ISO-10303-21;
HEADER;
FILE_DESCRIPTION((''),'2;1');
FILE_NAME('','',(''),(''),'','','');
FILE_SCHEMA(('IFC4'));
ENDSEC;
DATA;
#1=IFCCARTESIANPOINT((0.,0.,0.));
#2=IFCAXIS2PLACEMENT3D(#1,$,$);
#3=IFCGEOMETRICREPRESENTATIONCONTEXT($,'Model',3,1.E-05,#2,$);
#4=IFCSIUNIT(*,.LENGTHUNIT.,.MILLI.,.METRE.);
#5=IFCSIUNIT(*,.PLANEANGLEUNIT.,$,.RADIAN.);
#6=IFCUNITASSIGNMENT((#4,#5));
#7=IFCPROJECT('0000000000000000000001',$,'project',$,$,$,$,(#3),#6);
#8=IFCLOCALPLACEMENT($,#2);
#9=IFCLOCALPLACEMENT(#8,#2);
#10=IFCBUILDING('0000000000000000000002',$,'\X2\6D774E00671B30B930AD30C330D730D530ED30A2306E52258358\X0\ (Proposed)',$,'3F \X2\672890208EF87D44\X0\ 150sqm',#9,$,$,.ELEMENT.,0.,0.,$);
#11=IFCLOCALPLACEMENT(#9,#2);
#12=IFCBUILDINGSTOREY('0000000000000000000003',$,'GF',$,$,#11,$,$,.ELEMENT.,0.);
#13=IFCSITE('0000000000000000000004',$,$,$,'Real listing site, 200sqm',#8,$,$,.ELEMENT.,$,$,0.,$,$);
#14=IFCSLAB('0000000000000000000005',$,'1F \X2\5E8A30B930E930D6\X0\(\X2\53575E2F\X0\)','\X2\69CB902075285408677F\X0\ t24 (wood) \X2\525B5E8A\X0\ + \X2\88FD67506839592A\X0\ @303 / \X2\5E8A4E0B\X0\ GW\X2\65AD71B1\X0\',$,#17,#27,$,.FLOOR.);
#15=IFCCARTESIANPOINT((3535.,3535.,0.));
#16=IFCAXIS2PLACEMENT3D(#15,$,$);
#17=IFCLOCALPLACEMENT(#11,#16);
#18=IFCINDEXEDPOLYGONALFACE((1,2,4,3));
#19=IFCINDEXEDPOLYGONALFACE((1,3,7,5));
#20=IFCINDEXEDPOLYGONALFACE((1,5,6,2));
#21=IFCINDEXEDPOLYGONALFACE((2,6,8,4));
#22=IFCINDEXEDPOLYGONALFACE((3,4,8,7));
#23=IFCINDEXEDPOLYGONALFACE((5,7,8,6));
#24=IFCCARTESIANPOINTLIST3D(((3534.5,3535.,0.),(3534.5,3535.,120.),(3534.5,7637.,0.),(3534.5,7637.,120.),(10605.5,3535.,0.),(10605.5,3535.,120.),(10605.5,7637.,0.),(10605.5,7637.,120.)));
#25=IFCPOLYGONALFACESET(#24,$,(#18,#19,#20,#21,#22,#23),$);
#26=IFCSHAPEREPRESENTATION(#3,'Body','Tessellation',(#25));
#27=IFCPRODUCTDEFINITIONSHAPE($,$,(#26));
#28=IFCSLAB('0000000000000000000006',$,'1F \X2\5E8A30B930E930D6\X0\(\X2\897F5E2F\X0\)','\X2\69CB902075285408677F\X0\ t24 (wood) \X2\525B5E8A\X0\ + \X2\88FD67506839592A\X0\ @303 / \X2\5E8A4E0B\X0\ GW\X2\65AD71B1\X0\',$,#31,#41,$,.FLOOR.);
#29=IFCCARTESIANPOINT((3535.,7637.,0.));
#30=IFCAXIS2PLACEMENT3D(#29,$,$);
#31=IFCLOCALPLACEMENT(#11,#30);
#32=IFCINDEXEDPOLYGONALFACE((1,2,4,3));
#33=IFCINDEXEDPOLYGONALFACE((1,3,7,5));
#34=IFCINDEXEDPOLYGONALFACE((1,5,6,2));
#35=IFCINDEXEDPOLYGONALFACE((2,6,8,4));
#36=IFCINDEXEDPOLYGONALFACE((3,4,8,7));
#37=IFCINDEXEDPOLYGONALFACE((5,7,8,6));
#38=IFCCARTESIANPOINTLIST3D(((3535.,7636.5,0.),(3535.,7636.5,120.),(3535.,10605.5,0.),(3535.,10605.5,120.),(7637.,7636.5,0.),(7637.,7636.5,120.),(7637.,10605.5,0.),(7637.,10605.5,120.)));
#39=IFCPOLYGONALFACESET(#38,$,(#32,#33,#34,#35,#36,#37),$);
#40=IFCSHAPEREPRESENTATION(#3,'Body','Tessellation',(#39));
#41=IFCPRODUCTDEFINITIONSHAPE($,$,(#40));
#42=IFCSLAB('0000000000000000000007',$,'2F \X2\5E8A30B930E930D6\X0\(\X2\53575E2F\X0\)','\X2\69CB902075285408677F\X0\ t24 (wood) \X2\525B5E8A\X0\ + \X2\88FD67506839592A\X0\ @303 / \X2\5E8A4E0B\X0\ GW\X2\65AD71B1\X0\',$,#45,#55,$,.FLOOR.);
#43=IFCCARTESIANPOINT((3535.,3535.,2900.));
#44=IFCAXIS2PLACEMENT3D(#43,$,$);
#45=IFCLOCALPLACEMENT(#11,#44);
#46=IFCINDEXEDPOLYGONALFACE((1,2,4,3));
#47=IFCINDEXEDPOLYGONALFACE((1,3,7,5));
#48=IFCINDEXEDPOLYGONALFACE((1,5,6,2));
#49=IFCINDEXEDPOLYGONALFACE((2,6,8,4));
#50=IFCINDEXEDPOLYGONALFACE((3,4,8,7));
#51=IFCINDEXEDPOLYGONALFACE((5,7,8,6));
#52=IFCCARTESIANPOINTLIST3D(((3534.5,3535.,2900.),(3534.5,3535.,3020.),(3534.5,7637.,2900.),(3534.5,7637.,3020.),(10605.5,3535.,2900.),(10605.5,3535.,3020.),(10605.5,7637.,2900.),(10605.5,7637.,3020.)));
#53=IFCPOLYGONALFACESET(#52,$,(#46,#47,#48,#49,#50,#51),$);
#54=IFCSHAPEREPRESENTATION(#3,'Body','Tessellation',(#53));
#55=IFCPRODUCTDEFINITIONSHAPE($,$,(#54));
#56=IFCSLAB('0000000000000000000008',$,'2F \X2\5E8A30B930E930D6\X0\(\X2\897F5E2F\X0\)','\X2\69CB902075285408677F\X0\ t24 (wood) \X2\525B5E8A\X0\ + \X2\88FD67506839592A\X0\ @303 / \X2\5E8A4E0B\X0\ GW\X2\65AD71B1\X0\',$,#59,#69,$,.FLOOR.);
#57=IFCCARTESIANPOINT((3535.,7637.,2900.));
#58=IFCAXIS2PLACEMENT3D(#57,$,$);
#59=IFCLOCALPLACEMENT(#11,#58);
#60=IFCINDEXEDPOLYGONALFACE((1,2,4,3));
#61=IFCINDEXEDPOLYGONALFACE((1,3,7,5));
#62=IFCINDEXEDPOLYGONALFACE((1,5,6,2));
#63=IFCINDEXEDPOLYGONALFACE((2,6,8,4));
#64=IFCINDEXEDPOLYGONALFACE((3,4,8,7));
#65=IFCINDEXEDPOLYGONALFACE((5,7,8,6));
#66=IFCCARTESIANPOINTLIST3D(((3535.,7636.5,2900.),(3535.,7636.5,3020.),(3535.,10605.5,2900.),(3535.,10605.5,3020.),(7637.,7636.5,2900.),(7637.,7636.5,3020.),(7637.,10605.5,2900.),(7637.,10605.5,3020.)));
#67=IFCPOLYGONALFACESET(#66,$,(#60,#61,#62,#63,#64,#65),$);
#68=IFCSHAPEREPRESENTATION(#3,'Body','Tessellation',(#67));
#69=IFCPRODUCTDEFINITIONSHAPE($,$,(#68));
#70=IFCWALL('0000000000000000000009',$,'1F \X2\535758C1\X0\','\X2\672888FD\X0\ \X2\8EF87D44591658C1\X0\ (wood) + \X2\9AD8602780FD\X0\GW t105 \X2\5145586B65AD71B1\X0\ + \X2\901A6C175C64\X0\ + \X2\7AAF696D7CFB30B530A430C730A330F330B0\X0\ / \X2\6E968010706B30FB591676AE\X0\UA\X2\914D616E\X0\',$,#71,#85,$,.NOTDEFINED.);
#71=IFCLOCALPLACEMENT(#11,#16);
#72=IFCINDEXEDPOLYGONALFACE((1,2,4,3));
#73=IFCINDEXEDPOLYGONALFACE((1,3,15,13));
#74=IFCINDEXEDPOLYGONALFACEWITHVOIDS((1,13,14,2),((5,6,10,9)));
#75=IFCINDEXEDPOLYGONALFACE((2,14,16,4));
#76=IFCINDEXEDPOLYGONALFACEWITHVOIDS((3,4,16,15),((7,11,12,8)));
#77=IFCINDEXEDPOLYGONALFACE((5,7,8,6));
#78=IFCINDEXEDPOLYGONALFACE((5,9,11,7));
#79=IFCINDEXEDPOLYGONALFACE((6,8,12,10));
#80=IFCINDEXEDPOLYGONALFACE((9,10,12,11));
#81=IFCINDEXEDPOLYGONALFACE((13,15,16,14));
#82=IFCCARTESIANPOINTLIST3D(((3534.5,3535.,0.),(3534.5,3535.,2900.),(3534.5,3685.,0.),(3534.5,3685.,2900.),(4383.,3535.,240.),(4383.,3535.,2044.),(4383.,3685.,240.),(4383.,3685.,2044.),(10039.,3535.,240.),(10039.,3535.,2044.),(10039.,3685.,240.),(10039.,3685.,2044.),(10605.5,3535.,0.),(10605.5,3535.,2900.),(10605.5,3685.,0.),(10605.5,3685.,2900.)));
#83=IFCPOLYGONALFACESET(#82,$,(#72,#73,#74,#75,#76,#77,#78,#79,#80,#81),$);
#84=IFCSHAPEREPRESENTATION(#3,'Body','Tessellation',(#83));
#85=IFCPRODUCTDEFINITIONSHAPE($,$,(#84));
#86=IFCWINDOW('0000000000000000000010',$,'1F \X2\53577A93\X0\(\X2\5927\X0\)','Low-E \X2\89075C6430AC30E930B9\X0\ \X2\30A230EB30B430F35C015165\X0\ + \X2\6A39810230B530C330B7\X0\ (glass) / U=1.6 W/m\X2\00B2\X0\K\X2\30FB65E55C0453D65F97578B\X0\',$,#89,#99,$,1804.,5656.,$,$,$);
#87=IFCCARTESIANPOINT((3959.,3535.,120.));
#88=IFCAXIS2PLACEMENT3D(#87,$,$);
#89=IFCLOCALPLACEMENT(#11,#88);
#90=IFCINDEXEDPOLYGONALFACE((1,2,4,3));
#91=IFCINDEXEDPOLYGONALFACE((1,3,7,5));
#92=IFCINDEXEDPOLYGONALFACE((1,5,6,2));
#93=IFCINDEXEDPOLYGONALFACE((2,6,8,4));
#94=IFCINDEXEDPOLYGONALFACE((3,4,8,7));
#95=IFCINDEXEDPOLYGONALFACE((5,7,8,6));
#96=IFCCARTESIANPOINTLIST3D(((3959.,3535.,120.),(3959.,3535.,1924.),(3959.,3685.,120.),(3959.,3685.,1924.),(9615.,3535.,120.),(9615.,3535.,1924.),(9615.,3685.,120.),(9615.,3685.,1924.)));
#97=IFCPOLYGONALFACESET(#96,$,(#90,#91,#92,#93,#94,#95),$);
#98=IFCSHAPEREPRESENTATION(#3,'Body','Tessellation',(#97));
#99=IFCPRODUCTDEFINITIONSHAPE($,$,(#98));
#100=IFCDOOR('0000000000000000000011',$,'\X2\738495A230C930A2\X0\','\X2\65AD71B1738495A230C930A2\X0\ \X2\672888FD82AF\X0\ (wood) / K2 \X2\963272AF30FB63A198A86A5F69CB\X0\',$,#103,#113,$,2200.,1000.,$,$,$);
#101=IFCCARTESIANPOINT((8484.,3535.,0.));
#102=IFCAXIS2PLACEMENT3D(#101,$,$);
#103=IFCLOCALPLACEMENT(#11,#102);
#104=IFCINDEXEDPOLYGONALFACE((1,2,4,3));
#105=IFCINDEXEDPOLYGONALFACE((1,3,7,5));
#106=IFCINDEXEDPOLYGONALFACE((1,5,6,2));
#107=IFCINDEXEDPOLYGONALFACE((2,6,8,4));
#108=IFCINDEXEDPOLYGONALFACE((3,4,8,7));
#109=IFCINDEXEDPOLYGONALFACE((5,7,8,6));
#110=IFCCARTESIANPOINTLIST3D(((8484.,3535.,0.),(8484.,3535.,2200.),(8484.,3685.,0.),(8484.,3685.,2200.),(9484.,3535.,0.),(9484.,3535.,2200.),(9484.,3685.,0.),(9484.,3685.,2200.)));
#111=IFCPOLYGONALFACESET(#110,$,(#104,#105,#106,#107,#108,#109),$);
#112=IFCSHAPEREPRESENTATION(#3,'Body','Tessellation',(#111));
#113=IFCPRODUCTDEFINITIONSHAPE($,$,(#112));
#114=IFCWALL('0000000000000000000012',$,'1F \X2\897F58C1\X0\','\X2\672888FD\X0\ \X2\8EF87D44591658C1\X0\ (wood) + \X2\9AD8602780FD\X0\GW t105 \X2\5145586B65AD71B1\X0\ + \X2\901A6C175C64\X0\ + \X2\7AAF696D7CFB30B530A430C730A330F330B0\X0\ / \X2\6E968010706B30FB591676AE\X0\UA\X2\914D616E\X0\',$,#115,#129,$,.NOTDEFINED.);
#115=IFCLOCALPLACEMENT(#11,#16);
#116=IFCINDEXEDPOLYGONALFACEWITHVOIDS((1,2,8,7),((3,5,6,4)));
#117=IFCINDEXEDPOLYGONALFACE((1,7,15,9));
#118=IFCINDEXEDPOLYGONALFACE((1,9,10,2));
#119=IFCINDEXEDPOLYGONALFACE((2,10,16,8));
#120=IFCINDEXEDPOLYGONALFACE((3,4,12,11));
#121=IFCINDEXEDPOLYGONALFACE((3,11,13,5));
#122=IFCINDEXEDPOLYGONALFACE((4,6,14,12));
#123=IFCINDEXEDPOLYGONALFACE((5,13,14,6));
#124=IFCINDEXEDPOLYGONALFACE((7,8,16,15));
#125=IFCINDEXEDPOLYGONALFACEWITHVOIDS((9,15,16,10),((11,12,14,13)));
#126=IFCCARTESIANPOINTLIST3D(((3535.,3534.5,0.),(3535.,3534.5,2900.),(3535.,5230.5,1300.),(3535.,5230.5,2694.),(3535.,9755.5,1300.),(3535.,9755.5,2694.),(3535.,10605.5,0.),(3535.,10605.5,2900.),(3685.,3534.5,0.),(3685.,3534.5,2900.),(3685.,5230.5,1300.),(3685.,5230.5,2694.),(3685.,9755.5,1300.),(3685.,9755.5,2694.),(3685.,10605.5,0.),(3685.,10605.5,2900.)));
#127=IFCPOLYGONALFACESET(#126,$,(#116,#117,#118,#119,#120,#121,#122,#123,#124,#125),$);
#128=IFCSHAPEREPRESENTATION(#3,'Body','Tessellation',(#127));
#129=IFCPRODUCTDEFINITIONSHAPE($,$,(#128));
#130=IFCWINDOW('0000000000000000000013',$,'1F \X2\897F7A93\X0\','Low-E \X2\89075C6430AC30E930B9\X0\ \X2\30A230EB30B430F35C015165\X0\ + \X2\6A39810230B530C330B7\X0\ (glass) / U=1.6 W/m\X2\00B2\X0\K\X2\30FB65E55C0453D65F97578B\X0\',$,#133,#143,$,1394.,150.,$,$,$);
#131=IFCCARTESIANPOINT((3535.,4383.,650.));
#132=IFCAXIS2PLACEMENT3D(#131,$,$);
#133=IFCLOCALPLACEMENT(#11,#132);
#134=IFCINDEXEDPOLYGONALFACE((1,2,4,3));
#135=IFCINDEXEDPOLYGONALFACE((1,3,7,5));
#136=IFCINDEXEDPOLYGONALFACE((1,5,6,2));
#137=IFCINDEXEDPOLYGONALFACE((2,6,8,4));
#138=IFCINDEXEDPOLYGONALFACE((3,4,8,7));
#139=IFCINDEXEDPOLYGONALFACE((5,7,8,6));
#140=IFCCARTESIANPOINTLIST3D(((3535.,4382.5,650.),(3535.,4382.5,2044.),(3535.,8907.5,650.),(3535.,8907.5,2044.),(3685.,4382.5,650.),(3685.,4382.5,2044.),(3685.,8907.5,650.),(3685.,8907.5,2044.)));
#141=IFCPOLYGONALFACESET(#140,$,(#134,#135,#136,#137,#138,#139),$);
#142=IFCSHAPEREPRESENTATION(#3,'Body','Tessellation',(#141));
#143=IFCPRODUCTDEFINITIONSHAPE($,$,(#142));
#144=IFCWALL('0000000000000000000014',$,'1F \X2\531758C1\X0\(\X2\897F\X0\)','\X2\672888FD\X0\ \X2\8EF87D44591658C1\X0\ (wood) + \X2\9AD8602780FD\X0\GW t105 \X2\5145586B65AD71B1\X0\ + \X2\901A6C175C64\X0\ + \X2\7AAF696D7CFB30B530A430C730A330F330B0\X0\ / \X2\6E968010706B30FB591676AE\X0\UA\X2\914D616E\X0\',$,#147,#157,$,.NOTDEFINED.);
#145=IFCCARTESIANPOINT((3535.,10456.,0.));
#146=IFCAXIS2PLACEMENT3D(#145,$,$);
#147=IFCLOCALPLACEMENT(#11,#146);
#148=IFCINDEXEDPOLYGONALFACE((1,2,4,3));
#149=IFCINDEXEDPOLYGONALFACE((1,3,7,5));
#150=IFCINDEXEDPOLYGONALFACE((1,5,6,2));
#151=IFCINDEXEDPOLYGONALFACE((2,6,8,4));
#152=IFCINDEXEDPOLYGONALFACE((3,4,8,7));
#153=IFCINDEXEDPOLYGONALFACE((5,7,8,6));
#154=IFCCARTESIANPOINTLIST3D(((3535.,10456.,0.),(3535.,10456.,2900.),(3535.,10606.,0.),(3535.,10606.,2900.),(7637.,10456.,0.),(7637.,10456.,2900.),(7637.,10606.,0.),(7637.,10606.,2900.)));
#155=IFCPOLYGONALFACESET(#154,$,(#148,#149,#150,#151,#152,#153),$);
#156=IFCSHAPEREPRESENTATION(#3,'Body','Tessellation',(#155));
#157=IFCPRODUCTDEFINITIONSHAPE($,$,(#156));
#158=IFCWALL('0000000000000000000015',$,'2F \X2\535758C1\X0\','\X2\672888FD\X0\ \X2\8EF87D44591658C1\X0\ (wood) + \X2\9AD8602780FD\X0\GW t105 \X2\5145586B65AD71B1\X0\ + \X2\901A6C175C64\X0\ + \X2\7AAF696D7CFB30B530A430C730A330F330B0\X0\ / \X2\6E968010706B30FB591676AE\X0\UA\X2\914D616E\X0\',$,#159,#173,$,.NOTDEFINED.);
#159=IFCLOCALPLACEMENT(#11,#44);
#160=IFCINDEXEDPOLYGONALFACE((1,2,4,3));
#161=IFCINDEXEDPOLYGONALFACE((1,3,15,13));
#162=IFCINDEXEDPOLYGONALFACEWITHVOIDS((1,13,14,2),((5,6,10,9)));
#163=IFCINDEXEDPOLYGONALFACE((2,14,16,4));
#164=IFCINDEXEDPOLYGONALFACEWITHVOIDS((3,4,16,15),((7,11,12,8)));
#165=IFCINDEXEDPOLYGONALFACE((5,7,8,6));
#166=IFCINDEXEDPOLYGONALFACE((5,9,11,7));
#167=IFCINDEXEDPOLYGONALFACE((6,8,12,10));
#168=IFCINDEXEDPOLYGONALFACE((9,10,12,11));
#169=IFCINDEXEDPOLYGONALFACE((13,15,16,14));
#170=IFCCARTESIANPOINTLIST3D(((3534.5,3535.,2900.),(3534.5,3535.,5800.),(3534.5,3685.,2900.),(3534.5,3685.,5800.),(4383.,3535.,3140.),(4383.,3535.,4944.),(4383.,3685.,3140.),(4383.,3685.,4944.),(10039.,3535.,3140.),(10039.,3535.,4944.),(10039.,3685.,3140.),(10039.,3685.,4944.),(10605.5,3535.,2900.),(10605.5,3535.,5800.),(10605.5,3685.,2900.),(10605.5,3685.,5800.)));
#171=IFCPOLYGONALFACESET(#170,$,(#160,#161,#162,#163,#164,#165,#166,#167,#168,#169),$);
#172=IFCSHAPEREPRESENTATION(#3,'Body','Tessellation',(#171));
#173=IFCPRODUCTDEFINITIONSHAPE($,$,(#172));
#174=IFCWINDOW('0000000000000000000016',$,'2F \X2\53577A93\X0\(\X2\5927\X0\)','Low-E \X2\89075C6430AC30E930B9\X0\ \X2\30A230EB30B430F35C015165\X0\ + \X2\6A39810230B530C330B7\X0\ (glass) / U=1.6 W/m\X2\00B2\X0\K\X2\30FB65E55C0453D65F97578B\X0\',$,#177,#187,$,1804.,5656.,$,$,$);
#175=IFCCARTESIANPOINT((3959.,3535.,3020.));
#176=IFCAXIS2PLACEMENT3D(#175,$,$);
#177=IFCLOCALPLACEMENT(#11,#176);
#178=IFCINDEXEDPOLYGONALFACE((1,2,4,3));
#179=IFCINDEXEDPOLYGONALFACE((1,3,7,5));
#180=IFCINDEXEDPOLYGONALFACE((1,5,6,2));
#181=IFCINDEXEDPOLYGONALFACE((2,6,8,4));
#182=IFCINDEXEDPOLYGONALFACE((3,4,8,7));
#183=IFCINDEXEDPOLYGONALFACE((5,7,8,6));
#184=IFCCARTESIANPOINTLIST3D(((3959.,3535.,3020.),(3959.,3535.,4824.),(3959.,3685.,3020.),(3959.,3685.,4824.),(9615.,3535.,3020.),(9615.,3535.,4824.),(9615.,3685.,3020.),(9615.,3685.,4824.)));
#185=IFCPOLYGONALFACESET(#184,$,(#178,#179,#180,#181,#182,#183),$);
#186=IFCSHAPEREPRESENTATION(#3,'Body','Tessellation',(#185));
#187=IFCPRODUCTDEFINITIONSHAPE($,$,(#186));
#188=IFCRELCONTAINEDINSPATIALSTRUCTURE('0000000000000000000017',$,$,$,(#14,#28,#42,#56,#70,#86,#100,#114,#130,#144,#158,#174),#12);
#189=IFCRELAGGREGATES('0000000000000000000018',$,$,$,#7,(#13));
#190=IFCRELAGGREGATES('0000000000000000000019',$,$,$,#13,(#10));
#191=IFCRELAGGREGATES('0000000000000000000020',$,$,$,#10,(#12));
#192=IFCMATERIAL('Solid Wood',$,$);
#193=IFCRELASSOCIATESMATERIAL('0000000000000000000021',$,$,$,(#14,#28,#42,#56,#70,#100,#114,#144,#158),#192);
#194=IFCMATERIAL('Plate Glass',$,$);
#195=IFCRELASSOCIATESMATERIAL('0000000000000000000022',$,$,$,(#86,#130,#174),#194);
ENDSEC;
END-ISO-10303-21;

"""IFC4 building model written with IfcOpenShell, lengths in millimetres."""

from ifc_helpers import new_model, si_unit, frame, frame_2d, origin, place, context, project, spatial, rectangle, extrude, material, element, fill, save


model = new_model("IFC4")

# Units and contexts
model_context = context("Model", 3, precision=1e-05, world=origin())
ifc_project = project(units=[si_unit("LENGTHUNIT", "METRE", prefix="MILLI"), si_unit("PLANEANGLEUNIT", "RADIAN")], contexts=[model_context])

# Site, building, storey
site_placement = place(None, origin())
site = spatial("IfcSite", under=ifc_project, at=site_placement, ObjectType="Real listing site, 200sqm", CompositionType="ELEMENT", RefElevation=0.0)
building_placement = place(site_placement, origin())
building = spatial("IfcBuilding", under=site, at=building_placement, Name="海一望スキップフロアの別荘 (Proposed)", ObjectType="3F 木造軸組 150sqm", CompositionType="ELEMENT", ElevationOfRefHeight=0.0, ElevationOfTerrain=0.0)
storey_placement = place(building_placement, origin())
storey = spatial("IfcBuildingStorey", under=building, at=storey_placement, Name="GF", CompositionType="ELEMENT", Elevation=0.0)

# Slabs
ifc_material_1 = material(Name="Solid Wood")
slab_1_placement = place(storey_placement, frame((3535.0, 3535.0, 0.0)))
element("IfcSlab", 1, at=slab_1_placement, inside=storey, material=ifc_material_1, Name="1F 床スラブ(南帯)", Description="構造用合板 t24 (wood) 剛床 + 製材根太 @303 / 床下 GW断熱", PredefinedType="FLOOR", context=model_context, shape_type="SweptSolid", body=[
    extrude(rectangle(XDim=7071.0, YDim=4102.0, at=frame_2d((3535.0, 2051.0))), frame((3535.0, 3535.0, 0.0)), (0.0, 0.0, 1.0), 120.0),
])
slab_2_placement = place(storey_placement, frame((3535.0, 7637.0, 0.0)))
element("IfcSlab", 2, at=slab_2_placement, inside=storey, material=ifc_material_1, Name="1F 床スラブ(西帯)", Description="構造用合板 t24 (wood) 剛床 + 製材根太 @303 / 床下 GW断熱", PredefinedType="FLOOR", context=model_context, shape_type="SweptSolid", body=[
    extrude(rectangle(XDim=4102.0, YDim=2969.0, at=frame_2d((2051.0, 1484.0))), frame((3535.0, 7637.0, 0.0)), (0.0, 0.0, 1.0), 120.0),
])
slab_3_placement = place(storey_placement, frame((3535.0, 3535.0, 2900.0)))
element("IfcSlab", 3, at=slab_3_placement, inside=storey, material=ifc_material_1, Name="2F 床スラブ(南帯)", Description="構造用合板 t24 (wood) 剛床 + 製材根太 @303 / 床下 GW断熱", PredefinedType="FLOOR", context=model_context, shape_type="SweptSolid", body=[
    extrude(rectangle(XDim=7071.0, YDim=4102.0, at=frame_2d((3535.0, 2051.0))), frame((3535.0, 3535.0, 2900.0)), (0.0, 0.0, 1.0), 120.0),
])
slab_4_placement = place(storey_placement, frame((3535.0, 7637.0, 2900.0)))
element("IfcSlab", 4, at=slab_4_placement, inside=storey, material=ifc_material_1, Name="2F 床スラブ(西帯)", Description="構造用合板 t24 (wood) 剛床 + 製材根太 @303 / 床下 GW断熱", PredefinedType="FLOOR", context=model_context, shape_type="SweptSolid", body=[
    extrude(rectangle(XDim=4102.0, YDim=2969.0, at=frame_2d((2051.0, 1484.0))), frame((3535.0, 7637.0, 2900.0)), (0.0, 0.0, 1.0), 120.0),
])

# Wall, openings, window, door
wall_1_placement = place(storey_placement, frame((3535.0, 3535.0, 0.0)))
wall_1 = element("IfcWall", 5, at=wall_1_placement, inside=storey, material=ifc_material_1, Name="1F 南壁", Description="木製 軸組外壁 (wood) + 高性能GW t105 充填断熱 + 通気層 + 窯業系サイディング / 準耐火・外皮UA配慮", PredefinedType="NOTDEFINED", context=model_context, shape_type="SweptSolid", body=[
    extrude(rectangle(XDim=7071.0, YDim=150.0, at=frame_2d((3535.0, 75.0))), frame((3535.0, 3535.0, 0.0)), (0.0, 0.0, 1.0), 2900.0),
])
opening_1_placement = place(storey_placement, frame((3959.0, 3535.0, 120.0)))
opening_1 = element("IfcOpeningElement", 6, at=opening_1_placement, cuts=wall_1, PredefinedType="NOTDEFINED", context=model_context, shape_type="SweptSolid", body=[
    extrude(rectangle(XDim=5656.0, YDim=150.0, at=frame_2d((2828.0, 75.0))), frame((3959.0, 3535.0, 120.0)), (0.0, 0.0, 1.0), 1804.0),
])
opening_2_placement = place(storey_placement, frame((8484.0, 3535.0, 0.0)))
opening_2 = element("IfcOpeningElement", 7, at=opening_2_placement, cuts=wall_1, PredefinedType="NOTDEFINED", context=model_context, shape_type="SweptSolid", body=[
    extrude(rectangle(XDim=1000.0, YDim=150.0, at=frame_2d((500.0, 75.0))), frame((8484.0, 3535.0, 0.0)), (0.0, 0.0, 1.0), 2200.0),
])
ifc_material_2 = material(Name="Plate Glass")
window_1_placement = place(storey_placement, frame((3959.0, 3535.0, 120.0)))
window_1 = element("IfcWindow", 8, at=window_1_placement, inside=storey, material=ifc_material_2, Name="1F 南窓(大)", Description="Low-E 複層ガラス アルゴン封入 + 樹脂サッシ (glass) / U=1.6 W/m²K・日射取得型", OverallHeight=1804.0, OverallWidth=5656.0, context=model_context, shape_type="SweptSolid", body=[
    extrude(rectangle(XDim=5656.0, YDim=150.0, at=frame_2d((2828.0, 75.0))), frame((3959.0, 3535.0, 120.0)), (0.0, 0.0, 1.0), 1804.0),
])
fill(opening_1, window_1)
door_placement = place(storey_placement, frame((8484.0, 3535.0, 0.0)))
door = element("IfcDoor", 9, at=door_placement, inside=storey, material=ifc_material_1, Name="玄関ドア", Description="断熱玄関ドア 木製芯 (wood) / K2 防犯・採風機構", OverallHeight=2200.0, OverallWidth=1000.0, context=model_context, shape_type="SweptSolid", body=[
    extrude(rectangle(XDim=1000.0, YDim=150.0, at=frame_2d((500.0, 75.0))), frame((8484.0, 3535.0, 0.0)), (0.0, 0.0, 1.0), 2200.0),
])
fill(opening_2, door)

# Wall, opening, window
wall_2_placement = place(storey_placement, frame((3535.0, 3535.0, 0.0)))
wall_2 = element("IfcWall", 10, at=wall_2_placement, inside=storey, material=ifc_material_1, Name="1F 西壁", Description="木製 軸組外壁 (wood) + 高性能GW t105 充填断熱 + 通気層 + 窯業系サイディング / 準耐火・外皮UA配慮", PredefinedType="NOTDEFINED", context=model_context, shape_type="SweptSolid", body=[
    extrude(rectangle(XDim=150.0, YDim=7071.0, at=frame_2d((75.0, 3535.0))), frame((3535.0, 3535.0, 0.0)), (0.0, 0.0, 1.0), 2900.0),
])
opening_3_placement = place(storey_placement, frame((3535.0, 4383.0, 650.0)))
opening_3 = element("IfcOpeningElement", 11, at=opening_3_placement, cuts=wall_2, PredefinedType="NOTDEFINED", context=model_context, shape_type="SweptSolid", body=[
    extrude(rectangle(XDim=150.0, YDim=4525.0, at=frame_2d((75.0, 2262.0))), frame((3535.0, 4383.0, 650.0)), (0.0, 0.0, 1.0), 1394.0),
])
window_2_placement = place(storey_placement, frame((3535.0, 4383.0, 650.0)))
window_2 = element("IfcWindow", 12, at=window_2_placement, inside=storey, material=ifc_material_2, Name="1F 西窓", Description="Low-E 複層ガラス アルゴン封入 + 樹脂サッシ (glass) / U=1.6 W/m²K・日射取得型", OverallHeight=1394.0, OverallWidth=150.0, context=model_context, shape_type="SweptSolid", body=[
    extrude(rectangle(XDim=150.0, YDim=4525.0, at=frame_2d((75.0, 2262.0))), frame((3535.0, 4383.0, 650.0)), (0.0, 0.0, 1.0), 1394.0),
])
fill(opening_3, window_2)

# Wall
wall_3_placement = place(storey_placement, frame((3535.0, 10456.0, 0.0)))
element("IfcWall", 13, at=wall_3_placement, inside=storey, material=ifc_material_1, Name="1F 北壁(西)", Description="木製 軸組外壁 (wood) + 高性能GW t105 充填断熱 + 通気層 + 窯業系サイディング / 準耐火・外皮UA配慮", PredefinedType="NOTDEFINED", context=model_context, shape_type="SweptSolid", body=[
    extrude(rectangle(XDim=4102.0, YDim=150.0, at=frame_2d((2051.0, 75.0))), frame((3535.0, 10456.0, 0.0)), (0.0, 0.0, 1.0), 2900.0),
])

# Wall, opening, window
wall_4_placement = place(storey_placement, frame((3535.0, 3535.0, 2900.0)))
wall_4 = element("IfcWall", 14, at=wall_4_placement, inside=storey, material=ifc_material_1, Name="2F 南壁", Description="木製 軸組外壁 (wood) + 高性能GW t105 充填断熱 + 通気層 + 窯業系サイディング / 準耐火・外皮UA配慮", PredefinedType="NOTDEFINED", context=model_context, shape_type="SweptSolid", body=[
    extrude(rectangle(XDim=7071.0, YDim=150.0, at=frame_2d((3535.0, 75.0))), frame((3535.0, 3535.0, 2900.0)), (0.0, 0.0, 1.0), 2900.0),
])
opening_4_placement = place(storey_placement, frame((3959.0, 3535.0, 3020.0)))
opening_4 = element("IfcOpeningElement", 15, at=opening_4_placement, cuts=wall_4, PredefinedType="NOTDEFINED", context=model_context, shape_type="SweptSolid", body=[
    extrude(rectangle(XDim=5656.0, YDim=150.0, at=frame_2d((2828.0, 75.0))), frame((3959.0, 3535.0, 3020.0)), (0.0, 0.0, 1.0), 1804.0),
])
window_3_placement = place(storey_placement, frame((3959.0, 3535.0, 3020.0)))
window_3 = element("IfcWindow", 16, at=window_3_placement, inside=storey, material=ifc_material_2, Name="2F 南窓(大)", Description="Low-E 複層ガラス アルゴン封入 + 樹脂サッシ (glass) / U=1.6 W/m²K・日射取得型", OverallHeight=1804.0, OverallWidth=5656.0, context=model_context, shape_type="SweptSolid", body=[
    extrude(rectangle(XDim=5656.0, YDim=150.0, at=frame_2d((2828.0, 75.0))), frame((3959.0, 3535.0, 3020.0)), (0.0, 0.0, 1.0), 1804.0),
])
fill(opening_4, window_3)

save(model, "model.ifc")
